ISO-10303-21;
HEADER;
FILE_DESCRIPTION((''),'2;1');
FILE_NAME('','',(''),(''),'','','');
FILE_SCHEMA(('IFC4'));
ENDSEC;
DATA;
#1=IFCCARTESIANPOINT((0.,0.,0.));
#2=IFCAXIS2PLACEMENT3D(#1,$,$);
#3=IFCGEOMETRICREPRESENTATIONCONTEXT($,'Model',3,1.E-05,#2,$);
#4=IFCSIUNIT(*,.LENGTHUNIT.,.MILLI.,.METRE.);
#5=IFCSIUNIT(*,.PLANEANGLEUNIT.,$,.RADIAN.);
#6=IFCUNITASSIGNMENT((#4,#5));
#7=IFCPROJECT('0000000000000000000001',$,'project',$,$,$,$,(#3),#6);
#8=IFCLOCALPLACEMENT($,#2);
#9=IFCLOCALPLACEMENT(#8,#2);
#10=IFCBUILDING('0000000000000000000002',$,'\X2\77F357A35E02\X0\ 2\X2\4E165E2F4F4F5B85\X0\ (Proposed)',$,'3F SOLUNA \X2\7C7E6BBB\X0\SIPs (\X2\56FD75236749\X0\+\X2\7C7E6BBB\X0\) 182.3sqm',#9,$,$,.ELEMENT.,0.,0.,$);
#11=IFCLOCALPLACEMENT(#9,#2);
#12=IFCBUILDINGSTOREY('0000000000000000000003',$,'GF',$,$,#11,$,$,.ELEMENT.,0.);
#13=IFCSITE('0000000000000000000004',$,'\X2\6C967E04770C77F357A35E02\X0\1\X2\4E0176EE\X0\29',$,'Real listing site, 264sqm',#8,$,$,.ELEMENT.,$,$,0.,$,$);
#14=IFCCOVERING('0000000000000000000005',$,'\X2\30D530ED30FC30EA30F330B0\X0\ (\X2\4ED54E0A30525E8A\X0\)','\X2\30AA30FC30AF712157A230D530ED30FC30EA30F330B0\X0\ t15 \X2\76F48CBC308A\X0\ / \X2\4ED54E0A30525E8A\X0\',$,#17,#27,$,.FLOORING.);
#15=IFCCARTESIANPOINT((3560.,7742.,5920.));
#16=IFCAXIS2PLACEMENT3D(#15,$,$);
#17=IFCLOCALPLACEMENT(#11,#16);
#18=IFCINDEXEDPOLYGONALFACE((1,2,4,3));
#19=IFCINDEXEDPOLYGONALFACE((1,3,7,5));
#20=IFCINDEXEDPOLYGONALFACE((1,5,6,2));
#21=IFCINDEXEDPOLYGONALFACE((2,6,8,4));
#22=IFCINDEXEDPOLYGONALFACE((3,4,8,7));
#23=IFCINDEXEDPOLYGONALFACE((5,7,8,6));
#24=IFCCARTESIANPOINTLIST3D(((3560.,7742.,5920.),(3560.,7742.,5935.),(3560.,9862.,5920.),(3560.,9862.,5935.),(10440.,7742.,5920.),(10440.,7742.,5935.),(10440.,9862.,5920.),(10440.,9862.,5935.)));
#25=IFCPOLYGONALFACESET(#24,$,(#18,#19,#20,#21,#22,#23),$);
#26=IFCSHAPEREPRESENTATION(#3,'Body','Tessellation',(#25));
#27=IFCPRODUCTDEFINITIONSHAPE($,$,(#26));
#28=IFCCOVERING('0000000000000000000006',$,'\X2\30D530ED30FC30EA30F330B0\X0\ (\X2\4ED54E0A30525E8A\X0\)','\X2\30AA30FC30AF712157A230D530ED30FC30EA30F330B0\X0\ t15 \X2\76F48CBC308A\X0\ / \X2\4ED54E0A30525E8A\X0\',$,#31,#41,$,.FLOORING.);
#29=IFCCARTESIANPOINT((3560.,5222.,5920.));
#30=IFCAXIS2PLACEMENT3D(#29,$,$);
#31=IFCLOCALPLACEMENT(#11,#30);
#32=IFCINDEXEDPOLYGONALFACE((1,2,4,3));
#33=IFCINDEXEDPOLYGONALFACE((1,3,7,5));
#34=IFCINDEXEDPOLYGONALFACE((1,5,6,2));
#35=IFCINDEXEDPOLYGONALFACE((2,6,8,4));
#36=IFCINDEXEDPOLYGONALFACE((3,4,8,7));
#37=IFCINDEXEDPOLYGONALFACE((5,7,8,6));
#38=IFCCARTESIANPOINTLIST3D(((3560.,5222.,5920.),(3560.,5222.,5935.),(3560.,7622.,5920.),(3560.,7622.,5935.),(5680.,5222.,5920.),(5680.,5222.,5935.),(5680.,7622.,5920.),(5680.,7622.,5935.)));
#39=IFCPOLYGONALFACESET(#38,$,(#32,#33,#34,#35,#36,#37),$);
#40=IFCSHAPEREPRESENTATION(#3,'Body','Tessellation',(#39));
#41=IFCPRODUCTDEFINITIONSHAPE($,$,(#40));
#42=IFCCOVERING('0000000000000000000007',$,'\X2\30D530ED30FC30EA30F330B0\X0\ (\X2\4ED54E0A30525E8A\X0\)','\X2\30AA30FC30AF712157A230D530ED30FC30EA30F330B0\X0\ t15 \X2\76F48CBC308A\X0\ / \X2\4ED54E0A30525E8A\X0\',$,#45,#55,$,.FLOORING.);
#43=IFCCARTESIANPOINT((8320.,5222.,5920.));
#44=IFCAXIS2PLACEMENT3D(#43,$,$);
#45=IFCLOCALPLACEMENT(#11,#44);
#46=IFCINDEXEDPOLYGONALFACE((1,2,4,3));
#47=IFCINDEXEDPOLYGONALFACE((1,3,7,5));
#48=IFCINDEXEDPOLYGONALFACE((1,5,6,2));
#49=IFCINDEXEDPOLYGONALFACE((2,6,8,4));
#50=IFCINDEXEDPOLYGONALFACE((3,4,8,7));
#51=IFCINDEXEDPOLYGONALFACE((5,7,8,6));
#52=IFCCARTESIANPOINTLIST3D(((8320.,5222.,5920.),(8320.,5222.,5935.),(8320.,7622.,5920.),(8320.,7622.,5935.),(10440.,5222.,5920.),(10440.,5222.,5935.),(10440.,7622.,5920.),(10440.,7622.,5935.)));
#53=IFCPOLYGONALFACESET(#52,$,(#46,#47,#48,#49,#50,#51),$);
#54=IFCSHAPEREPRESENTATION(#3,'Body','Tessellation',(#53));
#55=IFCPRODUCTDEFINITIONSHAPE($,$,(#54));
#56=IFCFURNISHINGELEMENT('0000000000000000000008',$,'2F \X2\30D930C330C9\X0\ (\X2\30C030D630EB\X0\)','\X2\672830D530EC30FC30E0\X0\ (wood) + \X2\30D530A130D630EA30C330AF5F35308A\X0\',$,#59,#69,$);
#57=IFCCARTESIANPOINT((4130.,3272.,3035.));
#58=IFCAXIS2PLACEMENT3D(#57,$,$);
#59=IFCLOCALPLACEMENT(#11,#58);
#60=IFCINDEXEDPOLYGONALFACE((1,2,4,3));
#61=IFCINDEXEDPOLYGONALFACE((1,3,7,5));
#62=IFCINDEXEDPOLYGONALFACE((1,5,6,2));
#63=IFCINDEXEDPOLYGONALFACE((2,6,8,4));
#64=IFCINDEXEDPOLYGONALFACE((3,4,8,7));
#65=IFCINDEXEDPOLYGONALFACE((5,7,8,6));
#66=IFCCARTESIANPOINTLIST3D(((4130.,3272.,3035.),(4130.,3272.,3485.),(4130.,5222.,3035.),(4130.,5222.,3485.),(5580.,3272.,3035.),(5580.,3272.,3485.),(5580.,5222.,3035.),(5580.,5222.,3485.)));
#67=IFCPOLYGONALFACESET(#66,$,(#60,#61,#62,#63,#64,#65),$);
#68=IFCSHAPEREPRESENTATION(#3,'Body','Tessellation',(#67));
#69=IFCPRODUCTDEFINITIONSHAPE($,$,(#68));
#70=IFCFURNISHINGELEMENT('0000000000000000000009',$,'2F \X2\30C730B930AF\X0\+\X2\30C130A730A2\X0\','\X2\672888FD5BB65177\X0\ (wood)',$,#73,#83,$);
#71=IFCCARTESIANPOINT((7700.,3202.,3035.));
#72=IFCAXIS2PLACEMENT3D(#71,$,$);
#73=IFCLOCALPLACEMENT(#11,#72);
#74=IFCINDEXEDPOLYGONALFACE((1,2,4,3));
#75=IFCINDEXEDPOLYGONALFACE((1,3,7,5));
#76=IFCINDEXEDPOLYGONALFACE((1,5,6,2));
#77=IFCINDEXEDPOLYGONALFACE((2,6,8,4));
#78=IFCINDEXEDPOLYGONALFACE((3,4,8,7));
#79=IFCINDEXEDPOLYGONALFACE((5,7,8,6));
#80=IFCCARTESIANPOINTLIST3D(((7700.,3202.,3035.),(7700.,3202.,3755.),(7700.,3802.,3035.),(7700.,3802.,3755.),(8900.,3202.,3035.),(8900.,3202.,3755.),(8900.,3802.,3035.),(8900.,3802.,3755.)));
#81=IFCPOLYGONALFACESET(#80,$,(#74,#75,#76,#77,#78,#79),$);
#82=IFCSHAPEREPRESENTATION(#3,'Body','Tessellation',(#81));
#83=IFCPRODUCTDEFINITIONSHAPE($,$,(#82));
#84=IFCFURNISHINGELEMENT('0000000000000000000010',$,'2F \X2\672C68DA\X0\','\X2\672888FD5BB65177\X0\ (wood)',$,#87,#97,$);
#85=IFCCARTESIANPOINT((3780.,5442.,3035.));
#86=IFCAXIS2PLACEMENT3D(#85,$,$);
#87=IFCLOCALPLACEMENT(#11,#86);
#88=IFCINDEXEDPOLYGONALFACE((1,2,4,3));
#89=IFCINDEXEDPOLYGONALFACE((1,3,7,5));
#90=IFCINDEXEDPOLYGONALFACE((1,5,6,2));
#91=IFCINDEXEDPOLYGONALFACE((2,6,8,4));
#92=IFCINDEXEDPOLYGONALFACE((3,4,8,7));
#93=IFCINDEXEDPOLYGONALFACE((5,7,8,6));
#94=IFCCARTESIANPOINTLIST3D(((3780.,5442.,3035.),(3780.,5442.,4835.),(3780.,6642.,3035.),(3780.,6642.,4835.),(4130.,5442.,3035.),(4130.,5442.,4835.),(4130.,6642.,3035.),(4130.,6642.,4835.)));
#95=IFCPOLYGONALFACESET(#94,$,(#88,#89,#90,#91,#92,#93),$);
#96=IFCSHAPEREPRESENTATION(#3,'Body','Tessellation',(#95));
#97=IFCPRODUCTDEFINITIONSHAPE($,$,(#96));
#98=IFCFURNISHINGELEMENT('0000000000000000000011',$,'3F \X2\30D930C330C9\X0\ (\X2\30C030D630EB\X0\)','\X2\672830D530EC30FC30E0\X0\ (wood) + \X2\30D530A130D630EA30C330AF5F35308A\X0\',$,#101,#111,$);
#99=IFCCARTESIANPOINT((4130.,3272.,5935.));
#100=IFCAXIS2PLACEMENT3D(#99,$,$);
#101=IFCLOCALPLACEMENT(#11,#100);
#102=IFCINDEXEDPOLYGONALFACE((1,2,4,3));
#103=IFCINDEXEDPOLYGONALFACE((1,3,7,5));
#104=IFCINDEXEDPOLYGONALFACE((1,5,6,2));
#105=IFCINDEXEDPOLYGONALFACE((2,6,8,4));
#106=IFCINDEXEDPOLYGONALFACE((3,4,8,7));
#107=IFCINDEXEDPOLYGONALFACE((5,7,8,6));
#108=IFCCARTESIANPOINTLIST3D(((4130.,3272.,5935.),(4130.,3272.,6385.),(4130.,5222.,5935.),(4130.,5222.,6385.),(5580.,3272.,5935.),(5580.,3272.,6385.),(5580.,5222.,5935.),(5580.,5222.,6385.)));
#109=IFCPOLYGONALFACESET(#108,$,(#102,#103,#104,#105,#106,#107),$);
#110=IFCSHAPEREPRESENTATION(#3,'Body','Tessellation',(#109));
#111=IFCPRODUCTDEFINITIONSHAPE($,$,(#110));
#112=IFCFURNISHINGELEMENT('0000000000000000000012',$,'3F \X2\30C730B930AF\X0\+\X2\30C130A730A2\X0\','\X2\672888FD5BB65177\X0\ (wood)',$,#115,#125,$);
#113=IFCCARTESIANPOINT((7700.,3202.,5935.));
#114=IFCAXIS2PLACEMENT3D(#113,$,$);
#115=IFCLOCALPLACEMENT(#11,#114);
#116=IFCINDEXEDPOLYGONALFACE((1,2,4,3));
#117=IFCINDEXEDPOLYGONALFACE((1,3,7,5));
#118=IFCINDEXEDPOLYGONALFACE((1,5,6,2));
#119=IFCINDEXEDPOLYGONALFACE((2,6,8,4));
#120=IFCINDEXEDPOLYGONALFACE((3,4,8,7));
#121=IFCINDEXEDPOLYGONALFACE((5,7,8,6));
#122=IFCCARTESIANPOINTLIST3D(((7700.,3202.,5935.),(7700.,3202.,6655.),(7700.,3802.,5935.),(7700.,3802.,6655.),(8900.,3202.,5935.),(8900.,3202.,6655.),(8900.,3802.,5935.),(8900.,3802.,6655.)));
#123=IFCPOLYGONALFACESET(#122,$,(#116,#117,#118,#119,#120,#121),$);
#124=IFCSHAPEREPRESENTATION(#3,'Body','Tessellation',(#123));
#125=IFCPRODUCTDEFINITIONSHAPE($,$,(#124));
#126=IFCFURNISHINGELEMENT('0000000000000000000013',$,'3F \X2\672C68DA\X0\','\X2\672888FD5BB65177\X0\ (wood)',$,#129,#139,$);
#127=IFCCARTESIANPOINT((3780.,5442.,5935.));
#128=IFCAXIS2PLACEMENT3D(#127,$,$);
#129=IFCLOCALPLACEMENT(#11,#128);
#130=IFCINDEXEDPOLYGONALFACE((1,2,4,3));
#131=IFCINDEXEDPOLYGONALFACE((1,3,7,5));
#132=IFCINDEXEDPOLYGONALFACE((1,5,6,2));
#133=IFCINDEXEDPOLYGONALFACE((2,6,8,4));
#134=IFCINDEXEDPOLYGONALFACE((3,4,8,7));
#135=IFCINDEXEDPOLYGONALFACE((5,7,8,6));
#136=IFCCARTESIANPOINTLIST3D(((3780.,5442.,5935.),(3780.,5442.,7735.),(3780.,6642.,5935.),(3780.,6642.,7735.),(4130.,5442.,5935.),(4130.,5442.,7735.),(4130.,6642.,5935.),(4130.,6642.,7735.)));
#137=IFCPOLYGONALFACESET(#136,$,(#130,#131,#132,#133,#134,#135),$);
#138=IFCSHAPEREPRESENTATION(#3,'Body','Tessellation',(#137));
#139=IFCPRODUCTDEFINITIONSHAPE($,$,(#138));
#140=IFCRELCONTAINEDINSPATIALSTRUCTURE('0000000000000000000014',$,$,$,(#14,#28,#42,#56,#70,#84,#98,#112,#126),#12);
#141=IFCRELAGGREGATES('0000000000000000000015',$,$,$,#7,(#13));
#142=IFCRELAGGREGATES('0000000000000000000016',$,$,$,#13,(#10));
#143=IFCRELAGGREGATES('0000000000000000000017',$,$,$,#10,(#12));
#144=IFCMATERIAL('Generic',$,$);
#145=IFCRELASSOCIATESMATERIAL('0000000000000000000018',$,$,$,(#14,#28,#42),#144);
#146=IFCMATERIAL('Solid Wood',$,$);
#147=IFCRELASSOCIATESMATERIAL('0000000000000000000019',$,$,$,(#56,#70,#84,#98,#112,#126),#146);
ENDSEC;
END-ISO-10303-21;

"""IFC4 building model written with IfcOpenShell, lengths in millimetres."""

from ifc_helpers import new_model, si_unit, frame, frame_2d, origin, place, context, project, spatial, rectangle, extrude, material, element, save


model = new_model("IFC4")

# Units and contexts
model_context = context("Model", 3, precision=1e-05, world=origin())
ifc_project = project(units=[si_unit("LENGTHUNIT", "METRE", prefix="MILLI"), si_unit("PLANEANGLEUNIT", "RADIAN")], contexts=[model_context])

# Site, building, storey
site_placement = place(None, origin())
site = spatial("IfcSite", under=ifc_project, at=site_placement, Name="沖縄県石垣市1丁目29", ObjectType="Real listing site, 264sqm", CompositionType="ELEMENT", RefElevation=0.0)
building_placement = place(site_placement, origin())
building = spatial("IfcBuilding", under=site, at=building_placement, Name="石垣市 2世帯住宅 (Proposed)", ObjectType="3F SOLUNA 籾殻SIPs (国産杉+籾殻) 182.3sqm", CompositionType="ELEMENT", ElevationOfRefHeight=0.0, ElevationOfTerrain=0.0)
storey_placement = place(building_placement, origin())
storey = spatial("IfcBuildingStorey", under=building, at=storey_placement, Name="GF", CompositionType="ELEMENT", Elevation=0.0)

# Shared definitions
ifc_material_1 = material(Name="Solid Wood")

# Shared definitions
ifc_material_2 = material(Name="Generic")

# Coverings
covering_1_placement = place(storey_placement, frame((3560.0, 7742.0, 5920.0)))
element("IfcCovering", 1, at=covering_1_placement, inside=storey, material=ifc_material_2, Name="フローリング (仕上げ床)", Description="オーク無垢フローリング t15 直貼り / 仕上げ床", PredefinedType="FLOORING", context=model_context, shape_type="SweptSolid", body=[
    extrude(rectangle(XDim=6880.0, YDim=2120.0, at=frame_2d((3440.0, 1060.0))), frame((3560.0, 7742.0, 5920.0)), (0.0, 0.0, 1.0), 15.0),
])
covering_2_placement = place(storey_placement, frame((3560.0, 5222.0, 5920.0)))
element("IfcCovering", 2, at=covering_2_placement, inside=storey, material=ifc_material_2, Name="フローリング (仕上げ床)", Description="オーク無垢フローリング t15 直貼り / 仕上げ床", PredefinedType="FLOORING", context=model_context, shape_type="SweptSolid", body=[
    extrude(rectangle(XDim=2120.0, YDim=2400.0, at=frame_2d((1060.0, 1200.0))), frame((3560.0, 5222.0, 5920.0)), (0.0, 0.0, 1.0), 15.0),
])
covering_3_placement = place(storey_placement, frame((8320.0, 5222.0, 5920.0)))
element("IfcCovering", 3, at=covering_3_placement, inside=storey, material=ifc_material_2, Name="フローリング (仕上げ床)", Description="オーク無垢フローリング t15 直貼り / 仕上げ床", PredefinedType="FLOORING", context=model_context, shape_type="SweptSolid", body=[
    extrude(rectangle(XDim=2120.0, YDim=2400.0, at=frame_2d((1060.0, 1200.0))), frame((8320.0, 5222.0, 5920.0)), (0.0, 0.0, 1.0), 15.0),
])

# Furnishing elements
furnishing_1_placement = place(storey_placement, frame((4130.0, 3272.0, 3035.0)))
element("IfcFurnishingElement", 4, at=furnishing_1_placement, inside=storey, material=ifc_material_1, Name="2F ベッド (ダブル)", Description="木フレーム (wood) + ファブリック張り", context=model_context, shape_type="SweptSolid", body=[
    extrude(rectangle(XDim=1450.0, YDim=1950.0, at=frame_2d((725.0, 975.0))), frame((4130.0, 3272.0, 3035.0)), (0.0, 0.0, 1.0), 450.0),
])
furnishing_2_placement = place(storey_placement, frame((7700.0, 3202.0, 3035.0)))
element("IfcFurnishingElement", 5, at=furnishing_2_placement, inside=storey, material=ifc_material_1, Name="2F デスク+チェア", Description="木製家具 (wood)", context=model_context, shape_type="SweptSolid", body=[
    extrude(rectangle(XDim=1200.0, YDim=600.0, at=frame_2d((600.0, 300.0))), frame((7700.0, 3202.0, 3035.0)), (0.0, 0.0, 1.0), 720.0),
])
furnishing_3_placement = place(storey_placement, frame((3780.0, 5442.0, 3035.0)))
element("IfcFurnishingElement", 6, at=furnishing_3_placement, inside=storey, material=ifc_material_1, Name="2F 本棚", Description="木製家具 (wood)", context=model_context, shape_type="SweptSolid", body=[
    extrude(rectangle(XDim=350.0, YDim=1200.0, at=frame_2d((175.0, 600.0))), frame((3780.0, 5442.0, 3035.0)), (0.0, 0.0, 1.0), 1800.0),
])
furnishing_4_placement = place(storey_placement, frame((4130.0, 3272.0, 5935.0)))
element("IfcFurnishingElement", 7, at=furnishing_4_placement, inside=storey, material=ifc_material_1, Name="3F ベッド (ダブル)", Description="木フレーム (wood) + ファブリック張り", context=model_context, shape_type="SweptSolid", body=[
    extrude(rectangle(XDim=1450.0, YDim=1950.0, at=frame_2d((725.0, 975.0))), frame((4130.0, 3272.0, 5935.0)), (0.0, 0.0, 1.0), 450.0),
])
furnishing_5_placement = place(storey_placement, frame((7700.0, 3202.0, 5935.0)))
element("IfcFurnishingElement", 8, at=furnishing_5_placement, inside=storey, material=ifc_material_1, Name="3F デスク+チェア", Description="木製家具 (wood)", context=model_context, shape_type="SweptSolid", body=[
    extrude(rectangle(XDim=1200.0, YDim=600.0, at=frame_2d((600.0, 300.0))), frame((7700.0, 3202.0, 5935.0)), (0.0, 0.0, 1.0), 720.0),
])
furnishing_6_placement = place(storey_placement, frame((3780.0, 5442.0, 5935.0)))
element("IfcFurnishingElement", 9, at=furnishing_6_placement, inside=storey, material=ifc_material_1, Name="3F 本棚", Description="木製家具 (wood)", context=model_context, shape_type="SweptSolid", body=[
    extrude(rectangle(XDim=350.0, YDim=1200.0, at=frame_2d((175.0, 600.0))), frame((3780.0, 5442.0, 5935.0)), (0.0, 0.0, 1.0), 1800.0),
])

save(model, "model.ifc")
